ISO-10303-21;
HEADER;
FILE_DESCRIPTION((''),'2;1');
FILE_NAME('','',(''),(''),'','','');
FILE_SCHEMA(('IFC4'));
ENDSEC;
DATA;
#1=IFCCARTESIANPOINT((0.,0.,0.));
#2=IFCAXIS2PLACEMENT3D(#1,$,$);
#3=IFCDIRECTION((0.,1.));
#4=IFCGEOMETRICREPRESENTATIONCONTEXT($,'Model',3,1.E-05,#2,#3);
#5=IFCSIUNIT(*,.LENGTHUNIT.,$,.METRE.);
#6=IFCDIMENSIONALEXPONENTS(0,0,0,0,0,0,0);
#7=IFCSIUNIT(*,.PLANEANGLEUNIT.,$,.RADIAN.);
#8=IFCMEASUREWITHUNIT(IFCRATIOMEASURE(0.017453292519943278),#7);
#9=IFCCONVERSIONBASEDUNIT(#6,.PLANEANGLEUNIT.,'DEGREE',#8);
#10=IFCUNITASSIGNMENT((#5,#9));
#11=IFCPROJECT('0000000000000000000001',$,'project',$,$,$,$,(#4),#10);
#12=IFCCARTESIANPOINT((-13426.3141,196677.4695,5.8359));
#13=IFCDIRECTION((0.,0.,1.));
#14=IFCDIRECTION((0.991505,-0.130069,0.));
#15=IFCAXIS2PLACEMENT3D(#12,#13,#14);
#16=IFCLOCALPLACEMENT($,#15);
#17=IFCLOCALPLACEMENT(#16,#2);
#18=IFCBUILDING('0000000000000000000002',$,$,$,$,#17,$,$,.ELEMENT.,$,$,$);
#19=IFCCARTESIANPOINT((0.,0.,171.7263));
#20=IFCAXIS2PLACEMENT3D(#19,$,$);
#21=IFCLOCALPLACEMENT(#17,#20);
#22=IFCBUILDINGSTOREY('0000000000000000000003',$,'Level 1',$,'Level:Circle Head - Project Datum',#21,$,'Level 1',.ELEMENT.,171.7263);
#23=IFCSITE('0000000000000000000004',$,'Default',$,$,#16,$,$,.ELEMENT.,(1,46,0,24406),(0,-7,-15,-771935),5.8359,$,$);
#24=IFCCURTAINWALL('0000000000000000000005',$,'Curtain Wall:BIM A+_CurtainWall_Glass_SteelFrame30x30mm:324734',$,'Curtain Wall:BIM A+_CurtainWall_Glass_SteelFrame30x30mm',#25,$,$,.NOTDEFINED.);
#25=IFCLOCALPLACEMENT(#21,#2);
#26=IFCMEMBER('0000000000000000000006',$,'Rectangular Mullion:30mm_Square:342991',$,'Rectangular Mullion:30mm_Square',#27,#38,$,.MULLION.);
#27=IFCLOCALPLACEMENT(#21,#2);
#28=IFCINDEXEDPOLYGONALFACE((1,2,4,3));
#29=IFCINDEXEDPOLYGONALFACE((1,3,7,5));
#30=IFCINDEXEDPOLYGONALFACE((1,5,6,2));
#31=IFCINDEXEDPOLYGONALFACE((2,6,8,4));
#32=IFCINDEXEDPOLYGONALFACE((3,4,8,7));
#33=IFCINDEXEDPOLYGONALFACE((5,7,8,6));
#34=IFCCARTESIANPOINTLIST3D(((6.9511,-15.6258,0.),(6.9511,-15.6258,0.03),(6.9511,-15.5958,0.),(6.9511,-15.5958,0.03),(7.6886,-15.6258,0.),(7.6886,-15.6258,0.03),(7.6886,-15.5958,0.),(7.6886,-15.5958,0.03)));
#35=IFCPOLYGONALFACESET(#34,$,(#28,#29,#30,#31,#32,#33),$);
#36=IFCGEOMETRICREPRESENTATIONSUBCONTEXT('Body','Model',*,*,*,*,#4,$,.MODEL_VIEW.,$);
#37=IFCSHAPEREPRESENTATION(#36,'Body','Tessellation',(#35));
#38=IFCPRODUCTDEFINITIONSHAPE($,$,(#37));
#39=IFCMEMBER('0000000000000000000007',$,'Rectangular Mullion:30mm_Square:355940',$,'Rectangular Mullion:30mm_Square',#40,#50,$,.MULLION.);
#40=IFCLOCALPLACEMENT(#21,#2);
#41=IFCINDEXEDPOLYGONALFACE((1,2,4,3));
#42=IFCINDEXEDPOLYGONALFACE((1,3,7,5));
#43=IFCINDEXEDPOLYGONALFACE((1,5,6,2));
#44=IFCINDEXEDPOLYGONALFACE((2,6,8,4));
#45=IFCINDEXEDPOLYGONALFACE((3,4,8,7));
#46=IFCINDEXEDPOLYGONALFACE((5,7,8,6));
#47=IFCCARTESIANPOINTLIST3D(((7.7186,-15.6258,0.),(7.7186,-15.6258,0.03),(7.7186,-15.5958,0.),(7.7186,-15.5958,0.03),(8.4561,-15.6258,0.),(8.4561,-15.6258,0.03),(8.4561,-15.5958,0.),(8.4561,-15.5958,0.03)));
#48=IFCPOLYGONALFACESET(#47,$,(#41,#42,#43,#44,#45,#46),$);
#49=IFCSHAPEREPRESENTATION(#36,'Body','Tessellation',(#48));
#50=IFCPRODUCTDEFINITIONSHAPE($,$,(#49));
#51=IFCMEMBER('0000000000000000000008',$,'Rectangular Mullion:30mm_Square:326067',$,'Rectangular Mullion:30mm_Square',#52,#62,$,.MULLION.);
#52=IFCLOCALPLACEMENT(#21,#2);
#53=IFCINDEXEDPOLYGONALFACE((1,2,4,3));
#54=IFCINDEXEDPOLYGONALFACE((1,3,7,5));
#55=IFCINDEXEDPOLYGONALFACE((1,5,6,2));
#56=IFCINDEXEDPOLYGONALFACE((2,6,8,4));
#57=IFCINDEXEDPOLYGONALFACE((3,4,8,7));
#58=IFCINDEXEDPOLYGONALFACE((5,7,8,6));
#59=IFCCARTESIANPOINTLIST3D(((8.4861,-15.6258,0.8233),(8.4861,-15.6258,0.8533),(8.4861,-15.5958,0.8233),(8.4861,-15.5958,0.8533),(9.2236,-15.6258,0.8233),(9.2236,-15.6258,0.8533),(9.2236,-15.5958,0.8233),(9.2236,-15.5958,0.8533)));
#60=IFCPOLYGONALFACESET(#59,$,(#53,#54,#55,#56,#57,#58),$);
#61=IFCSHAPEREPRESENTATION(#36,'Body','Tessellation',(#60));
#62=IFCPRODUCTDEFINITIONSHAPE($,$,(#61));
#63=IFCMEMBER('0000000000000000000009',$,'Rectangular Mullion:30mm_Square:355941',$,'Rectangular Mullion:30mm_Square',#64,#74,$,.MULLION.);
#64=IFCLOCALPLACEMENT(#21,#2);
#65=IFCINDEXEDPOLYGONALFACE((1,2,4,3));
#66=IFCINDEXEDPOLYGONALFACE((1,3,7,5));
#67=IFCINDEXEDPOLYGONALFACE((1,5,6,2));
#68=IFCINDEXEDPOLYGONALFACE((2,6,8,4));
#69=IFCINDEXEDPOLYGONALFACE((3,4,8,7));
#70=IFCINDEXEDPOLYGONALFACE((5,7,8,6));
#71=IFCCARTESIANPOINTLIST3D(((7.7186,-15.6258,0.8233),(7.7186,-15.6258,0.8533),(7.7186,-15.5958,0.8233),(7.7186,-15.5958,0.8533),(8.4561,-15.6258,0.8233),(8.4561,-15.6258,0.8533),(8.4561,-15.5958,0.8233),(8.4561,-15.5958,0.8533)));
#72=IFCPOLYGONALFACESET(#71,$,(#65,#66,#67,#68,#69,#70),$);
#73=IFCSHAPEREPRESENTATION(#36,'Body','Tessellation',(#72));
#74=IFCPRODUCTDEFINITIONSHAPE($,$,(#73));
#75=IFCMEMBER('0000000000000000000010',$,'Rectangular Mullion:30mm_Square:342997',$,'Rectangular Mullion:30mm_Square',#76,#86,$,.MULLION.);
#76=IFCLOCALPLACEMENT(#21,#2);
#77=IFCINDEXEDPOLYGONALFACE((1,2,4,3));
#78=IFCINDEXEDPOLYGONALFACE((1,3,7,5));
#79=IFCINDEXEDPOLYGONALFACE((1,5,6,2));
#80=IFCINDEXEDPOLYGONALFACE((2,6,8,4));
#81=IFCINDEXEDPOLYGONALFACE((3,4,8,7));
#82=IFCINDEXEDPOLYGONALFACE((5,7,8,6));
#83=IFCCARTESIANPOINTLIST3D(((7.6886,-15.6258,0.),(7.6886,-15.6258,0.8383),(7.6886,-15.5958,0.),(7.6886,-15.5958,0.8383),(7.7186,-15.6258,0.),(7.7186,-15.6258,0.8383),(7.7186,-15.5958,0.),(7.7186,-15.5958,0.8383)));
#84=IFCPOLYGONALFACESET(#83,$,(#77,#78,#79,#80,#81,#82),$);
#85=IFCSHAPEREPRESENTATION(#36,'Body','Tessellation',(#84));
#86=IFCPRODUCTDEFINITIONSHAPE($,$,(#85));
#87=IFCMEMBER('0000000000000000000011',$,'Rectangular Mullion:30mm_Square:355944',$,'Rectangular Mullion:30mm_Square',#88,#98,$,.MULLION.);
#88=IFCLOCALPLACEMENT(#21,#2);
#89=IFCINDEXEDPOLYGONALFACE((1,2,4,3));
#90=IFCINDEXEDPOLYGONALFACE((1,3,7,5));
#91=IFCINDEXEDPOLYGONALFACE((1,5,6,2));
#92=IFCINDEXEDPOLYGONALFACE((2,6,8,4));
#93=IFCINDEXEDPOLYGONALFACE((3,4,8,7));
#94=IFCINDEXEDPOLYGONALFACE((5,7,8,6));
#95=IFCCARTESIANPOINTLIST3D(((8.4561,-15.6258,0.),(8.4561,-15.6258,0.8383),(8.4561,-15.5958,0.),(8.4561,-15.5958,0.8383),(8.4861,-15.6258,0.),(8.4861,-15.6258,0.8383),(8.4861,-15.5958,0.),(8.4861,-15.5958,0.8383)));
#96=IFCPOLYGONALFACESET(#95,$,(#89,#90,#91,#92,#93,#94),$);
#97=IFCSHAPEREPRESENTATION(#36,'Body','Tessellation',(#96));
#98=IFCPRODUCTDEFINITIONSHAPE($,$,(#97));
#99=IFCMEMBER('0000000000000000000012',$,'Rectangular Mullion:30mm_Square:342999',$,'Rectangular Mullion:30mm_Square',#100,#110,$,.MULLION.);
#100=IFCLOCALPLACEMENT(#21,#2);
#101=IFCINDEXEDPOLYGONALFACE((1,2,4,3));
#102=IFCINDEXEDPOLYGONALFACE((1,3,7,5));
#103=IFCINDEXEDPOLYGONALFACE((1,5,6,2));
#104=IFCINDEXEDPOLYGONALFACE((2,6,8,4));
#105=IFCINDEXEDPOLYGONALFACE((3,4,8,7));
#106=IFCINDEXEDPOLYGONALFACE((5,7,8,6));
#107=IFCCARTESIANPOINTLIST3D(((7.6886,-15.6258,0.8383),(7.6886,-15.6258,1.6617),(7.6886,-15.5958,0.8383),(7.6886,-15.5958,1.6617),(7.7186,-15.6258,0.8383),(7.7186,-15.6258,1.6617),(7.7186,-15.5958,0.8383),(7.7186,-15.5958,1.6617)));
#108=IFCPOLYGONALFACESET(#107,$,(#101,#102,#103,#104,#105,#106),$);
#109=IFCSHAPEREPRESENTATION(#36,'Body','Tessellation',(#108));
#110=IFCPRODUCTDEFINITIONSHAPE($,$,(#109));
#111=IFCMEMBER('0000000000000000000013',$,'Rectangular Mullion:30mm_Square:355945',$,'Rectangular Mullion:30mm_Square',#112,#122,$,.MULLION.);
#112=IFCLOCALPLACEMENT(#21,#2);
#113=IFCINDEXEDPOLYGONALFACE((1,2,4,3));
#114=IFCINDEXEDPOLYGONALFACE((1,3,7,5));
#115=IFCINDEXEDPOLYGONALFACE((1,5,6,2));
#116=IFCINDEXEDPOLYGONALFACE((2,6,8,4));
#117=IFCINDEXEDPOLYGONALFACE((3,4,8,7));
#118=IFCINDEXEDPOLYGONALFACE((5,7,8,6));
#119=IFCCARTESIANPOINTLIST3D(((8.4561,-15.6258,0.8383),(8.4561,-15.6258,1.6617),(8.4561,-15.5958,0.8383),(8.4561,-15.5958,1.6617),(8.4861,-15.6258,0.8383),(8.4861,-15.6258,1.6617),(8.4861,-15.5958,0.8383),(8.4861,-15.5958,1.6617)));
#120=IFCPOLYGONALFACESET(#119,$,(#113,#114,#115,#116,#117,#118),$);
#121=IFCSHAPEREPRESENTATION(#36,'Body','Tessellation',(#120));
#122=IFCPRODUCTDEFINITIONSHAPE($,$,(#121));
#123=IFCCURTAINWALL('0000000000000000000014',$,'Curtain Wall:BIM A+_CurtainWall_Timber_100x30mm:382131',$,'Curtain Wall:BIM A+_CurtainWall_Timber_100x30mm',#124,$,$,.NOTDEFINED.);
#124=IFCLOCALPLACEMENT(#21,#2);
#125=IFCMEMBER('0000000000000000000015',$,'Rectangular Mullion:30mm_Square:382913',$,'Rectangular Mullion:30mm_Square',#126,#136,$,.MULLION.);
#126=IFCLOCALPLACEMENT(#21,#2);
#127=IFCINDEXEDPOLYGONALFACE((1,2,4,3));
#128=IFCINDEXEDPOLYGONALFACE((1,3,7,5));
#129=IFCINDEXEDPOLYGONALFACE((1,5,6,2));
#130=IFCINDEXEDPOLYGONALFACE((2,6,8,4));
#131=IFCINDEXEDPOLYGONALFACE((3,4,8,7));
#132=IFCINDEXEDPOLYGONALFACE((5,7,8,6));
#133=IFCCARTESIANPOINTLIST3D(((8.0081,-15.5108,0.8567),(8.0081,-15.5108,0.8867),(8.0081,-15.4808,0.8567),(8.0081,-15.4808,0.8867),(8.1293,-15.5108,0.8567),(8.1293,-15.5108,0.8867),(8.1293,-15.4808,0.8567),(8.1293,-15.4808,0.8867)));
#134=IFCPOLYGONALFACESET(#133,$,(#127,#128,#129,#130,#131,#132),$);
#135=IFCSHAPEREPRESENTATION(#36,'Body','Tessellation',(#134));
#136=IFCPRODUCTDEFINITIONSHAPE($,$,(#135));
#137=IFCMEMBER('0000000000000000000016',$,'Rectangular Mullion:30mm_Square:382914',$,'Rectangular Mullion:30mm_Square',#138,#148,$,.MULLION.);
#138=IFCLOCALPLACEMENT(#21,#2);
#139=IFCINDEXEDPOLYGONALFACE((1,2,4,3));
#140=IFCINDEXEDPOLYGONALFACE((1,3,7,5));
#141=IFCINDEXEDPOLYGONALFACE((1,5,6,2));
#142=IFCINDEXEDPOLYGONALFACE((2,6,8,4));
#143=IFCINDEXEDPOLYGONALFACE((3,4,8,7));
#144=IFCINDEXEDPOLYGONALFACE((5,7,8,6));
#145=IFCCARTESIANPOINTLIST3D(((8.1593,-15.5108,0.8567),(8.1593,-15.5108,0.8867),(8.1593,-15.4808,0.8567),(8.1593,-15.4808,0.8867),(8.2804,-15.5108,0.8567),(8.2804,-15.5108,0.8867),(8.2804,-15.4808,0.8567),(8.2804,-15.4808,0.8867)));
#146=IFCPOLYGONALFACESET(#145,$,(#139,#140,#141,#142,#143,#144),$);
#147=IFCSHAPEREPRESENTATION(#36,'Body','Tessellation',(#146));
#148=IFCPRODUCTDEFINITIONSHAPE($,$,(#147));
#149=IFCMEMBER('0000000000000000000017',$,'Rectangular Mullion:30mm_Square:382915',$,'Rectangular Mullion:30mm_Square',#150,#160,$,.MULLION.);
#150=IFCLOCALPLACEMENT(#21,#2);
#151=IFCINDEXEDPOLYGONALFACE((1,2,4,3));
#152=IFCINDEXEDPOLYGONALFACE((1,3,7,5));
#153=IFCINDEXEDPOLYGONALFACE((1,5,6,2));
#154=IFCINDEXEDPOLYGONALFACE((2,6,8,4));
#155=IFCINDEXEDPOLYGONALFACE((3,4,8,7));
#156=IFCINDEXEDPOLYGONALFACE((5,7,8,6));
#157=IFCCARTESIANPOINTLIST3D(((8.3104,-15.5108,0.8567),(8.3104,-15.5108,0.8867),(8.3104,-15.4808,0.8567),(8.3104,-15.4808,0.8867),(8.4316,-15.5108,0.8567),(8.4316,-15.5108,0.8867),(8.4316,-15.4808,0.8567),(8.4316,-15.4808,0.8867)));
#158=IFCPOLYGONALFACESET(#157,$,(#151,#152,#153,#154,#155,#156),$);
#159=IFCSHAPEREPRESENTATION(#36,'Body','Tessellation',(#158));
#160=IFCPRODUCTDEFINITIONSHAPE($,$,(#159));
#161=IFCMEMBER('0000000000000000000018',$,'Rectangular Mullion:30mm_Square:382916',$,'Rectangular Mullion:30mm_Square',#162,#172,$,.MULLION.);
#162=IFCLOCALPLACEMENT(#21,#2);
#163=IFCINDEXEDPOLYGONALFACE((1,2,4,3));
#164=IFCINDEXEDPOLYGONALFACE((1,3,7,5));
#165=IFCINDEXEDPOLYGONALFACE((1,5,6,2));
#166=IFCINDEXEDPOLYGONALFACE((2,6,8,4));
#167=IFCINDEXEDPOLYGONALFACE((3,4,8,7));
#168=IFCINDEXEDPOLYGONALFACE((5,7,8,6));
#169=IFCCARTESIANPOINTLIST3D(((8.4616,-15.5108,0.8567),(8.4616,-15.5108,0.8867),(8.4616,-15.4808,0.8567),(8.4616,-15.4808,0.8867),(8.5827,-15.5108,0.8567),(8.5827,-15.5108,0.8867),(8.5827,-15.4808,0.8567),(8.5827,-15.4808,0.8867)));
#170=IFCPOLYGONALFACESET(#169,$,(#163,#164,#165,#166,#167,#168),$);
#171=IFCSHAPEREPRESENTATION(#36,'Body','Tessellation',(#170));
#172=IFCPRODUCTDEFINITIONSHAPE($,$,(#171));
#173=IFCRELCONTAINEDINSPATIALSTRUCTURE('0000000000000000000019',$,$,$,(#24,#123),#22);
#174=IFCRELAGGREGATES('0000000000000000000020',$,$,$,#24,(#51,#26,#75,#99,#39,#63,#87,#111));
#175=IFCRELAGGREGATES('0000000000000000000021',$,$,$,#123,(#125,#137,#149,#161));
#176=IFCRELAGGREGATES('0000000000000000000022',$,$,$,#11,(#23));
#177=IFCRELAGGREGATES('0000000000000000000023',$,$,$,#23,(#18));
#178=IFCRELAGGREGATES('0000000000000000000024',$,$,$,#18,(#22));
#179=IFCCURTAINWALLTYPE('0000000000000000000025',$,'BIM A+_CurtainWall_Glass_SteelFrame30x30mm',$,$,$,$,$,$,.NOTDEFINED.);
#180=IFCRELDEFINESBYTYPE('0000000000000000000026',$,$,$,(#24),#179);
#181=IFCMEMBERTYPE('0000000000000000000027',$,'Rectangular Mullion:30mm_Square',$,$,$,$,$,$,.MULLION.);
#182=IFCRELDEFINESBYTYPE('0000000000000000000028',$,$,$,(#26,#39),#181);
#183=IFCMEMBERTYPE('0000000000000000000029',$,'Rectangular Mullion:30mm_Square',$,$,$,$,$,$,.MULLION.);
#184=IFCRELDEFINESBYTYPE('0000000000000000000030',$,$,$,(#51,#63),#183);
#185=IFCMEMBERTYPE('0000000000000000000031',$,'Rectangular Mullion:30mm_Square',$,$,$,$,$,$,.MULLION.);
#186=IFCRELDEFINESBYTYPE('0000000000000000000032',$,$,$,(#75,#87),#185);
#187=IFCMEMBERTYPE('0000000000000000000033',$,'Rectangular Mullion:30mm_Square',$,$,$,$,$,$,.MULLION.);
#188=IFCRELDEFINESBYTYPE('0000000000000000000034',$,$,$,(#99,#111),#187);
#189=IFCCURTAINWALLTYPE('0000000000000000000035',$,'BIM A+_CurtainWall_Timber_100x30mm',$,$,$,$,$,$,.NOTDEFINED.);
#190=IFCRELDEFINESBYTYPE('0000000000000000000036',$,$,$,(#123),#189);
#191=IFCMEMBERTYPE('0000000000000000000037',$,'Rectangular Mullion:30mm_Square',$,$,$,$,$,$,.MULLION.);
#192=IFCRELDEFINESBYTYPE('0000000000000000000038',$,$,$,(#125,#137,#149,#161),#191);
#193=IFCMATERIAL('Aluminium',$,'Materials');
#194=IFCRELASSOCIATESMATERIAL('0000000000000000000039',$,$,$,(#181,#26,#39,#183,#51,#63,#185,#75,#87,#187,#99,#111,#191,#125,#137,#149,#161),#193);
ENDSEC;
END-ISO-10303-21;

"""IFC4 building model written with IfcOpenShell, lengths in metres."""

from ifc_helpers import new_model, entity, si_unit, converted_unit, direction, frame, origin, place, context, subcontext, project, spatial, indexed_curve, outline, extrude, source, transform, mapped, material, type_object, type_shapes, element, aggregate, save


model = new_model("IFC4")

# Units and contexts
model_context = context("Model", 3, precision=1e-05, world=origin(), true_north=direction((0.0, 1.0)))
body_context = subcontext(model_context, "Body", "Model", "MODEL_VIEW")
ifc_project = project(units=[si_unit("LENGTHUNIT", "METRE"), converted_unit("PLANEANGLEUNIT", "DEGREE", entity("IfcRatioMeasure", 0.017453292519943278), si_unit("PLANEANGLEUNIT", "RADIAN"), dimensions=[0, 0, 0, 0, 0, 0, 0])], contexts=[model_context])

# Site, building, storey
site_placement = place(None, frame((-13426.3141, 196677.4695, 5.8359), z_axis=(0.0, 0.0, 1.0), x_axis=(0.991505, -0.130069, 0.0)))
site = spatial("IfcSite", under=ifc_project, at=site_placement, Name="Default", CompositionType="ELEMENT", RefLatitude=(1, 46, 0, 24406), RefLongitude=(0, -7, -15, -771935), RefElevation=5.8359)
building_placement = place(site_placement, origin())
building = spatial("IfcBuilding", under=site, at=building_placement, CompositionType="ELEMENT")
storey_placement = place(building_placement, frame((0.0, 0.0, 171.7263)))
storey = spatial("IfcBuildingStorey", under=building, at=storey_placement, Name="Level 1", ObjectType="Level:Circle Head - Project Datum", LongName="Level 1", CompositionType="ELEMENT", Elevation=171.7263)

# Curtain walls, members
curtain_wall_type_1 = type_object("IfcCurtainWallType", Name="BIM A+_CurtainWall_Glass_SteelFrame30x30mm", PredefinedType="NOTDEFINED")
curtain_wall_1_placement = place(storey_placement, frame((0.0, 0.0, -171.7263)))
curtain_wall_1 = element("IfcCurtainWall", 1, at=curtain_wall_1_placement, inside=storey, type_object=curtain_wall_type_1, Name="Curtain Wall:BIM A+_CurtainWall_Glass_SteelFrame30x30mm:324734", ObjectType="Curtain Wall:BIM A+_CurtainWall_Glass_SteelFrame30x30mm", PredefinedType="NOTDEFINED")
ifc_material_1 = material(Name="Aluminium", Category="Materials")
member_type_1 = type_object("IfcMemberType", Name="Rectangular Mullion:30mm_Square", PredefinedType="MULLION", material=ifc_material_1)
shared_shape_1 = source(origin(), body_context, "Body", "SweptSolid", [
    extrude(outline(indexed_curve([(-0.015, -0.015), (0.015, -0.015), (0.015, 0.015), (-0.015, 0.015), (-0.015, -0.015)], self_intersect=False)), frame((-0.015, 0.0, -0.7375), z_axis=(0.0, 0.0, 1.0), x_axis=(0.0, -1.0, 0.0)), (0.0, 0.0, 1.0), 0.7375),
])
type_shapes(member_type_1, [shared_shape_1])
member_1_placement = place(curtain_wall_1_placement, frame((7.6886, -15.6108, 171.7263), z_axis=(1.0, 0.0, 0.0), x_axis=(0.0, 0.0, -1.0)))
member_1 = element("IfcMember", 2, at=member_1_placement, type_object=member_type_1, material=ifc_material_1, Name="Rectangular Mullion:30mm_Square:342991", ObjectType="Rectangular Mullion:30mm_Square", PredefinedType="MULLION", context=body_context, shape_type="MappedRepresentation", body=[
    mapped(shared_shape_1, transform((0.0, 0.0, 0.0), scale=1.0)),
])
member_2_placement = place(curtain_wall_1_placement, frame((8.4561, -15.6108, 171.7263), z_axis=(1.0, 0.0, 0.0), x_axis=(0.0, 0.0, -1.0)))
member_2 = element("IfcMember", 3, at=member_2_placement, type_object=member_type_1, material=ifc_material_1, Name="Rectangular Mullion:30mm_Square:355940", ObjectType="Rectangular Mullion:30mm_Square", PredefinedType="MULLION", context=body_context, shape_type="MappedRepresentation", body=[
    mapped(shared_shape_1, transform((0.0, 0.0, 0.0), scale=1.0)),
])
member_type_2 = type_object("IfcMemberType", Name="Rectangular Mullion:30mm_Square", PredefinedType="MULLION", material=ifc_material_1)
shared_shape_2 = source(origin(), body_context, "Body", "SweptSolid", [
    extrude(outline(indexed_curve([(-0.015, -0.015), (0.015, -0.015), (0.015, 0.015), (-0.015, 0.015), (-0.015, -0.015)], self_intersect=False)), frame((0.0, 0.0, -0.7375), z_axis=(0.0, 0.0, 1.0), x_axis=(0.0, -1.0, 0.0)), (0.0, 0.0, 1.0), 0.7375),
])
type_shapes(member_type_2, [shared_shape_2])
member_3_placement = place(curtain_wall_1_placement, frame((8.4861, -15.6108, 172.5646), z_axis=(-1.0, 0.0, 0.0), x_axis=(0.0, 0.0, 1.0)))
member_3 = element("IfcMember", 4, at=member_3_placement, type_object=member_type_2, material=ifc_material_1, Name="Rectangular Mullion:30mm_Square:326067", ObjectType="Rectangular Mullion:30mm_Square", PredefinedType="MULLION", context=body_context, shape_type="MappedRepresentation", body=[
    mapped(shared_shape_2, transform((0.0, 0.0, 0.0), scale=1.0)),
])
member_4_placement = place(curtain_wall_1_placement, frame((7.7186, -15.6108, 172.5646), z_axis=(-1.0, 0.0, 0.0), x_axis=(0.0, 0.0, 1.0)))
member_4 = element("IfcMember", 5, at=member_4_placement, type_object=member_type_2, material=ifc_material_1, Name="Rectangular Mullion:30mm_Square:355941", ObjectType="Rectangular Mullion:30mm_Square", PredefinedType="MULLION", context=body_context, shape_type="MappedRepresentation", body=[
    mapped(shared_shape_2, transform((0.0, 0.0, 0.0), scale=1.0)),
])
member_type_3 = type_object("IfcMemberType", Name="Rectangular Mullion:30mm_Square", PredefinedType="MULLION", material=ifc_material_1)
shared_shape_3 = source(origin(), body_context, "Body", "SweptSolid", [
    extrude(outline(indexed_curve([(-0.015, -0.015), (0.015, -0.015), (0.015, 0.015), (-0.015, 0.015), (-0.015, -0.015)], self_intersect=False)), frame((0.0, 0.0, -0.8383), z_axis=(0.0, 0.0, 1.0), x_axis=(0.0, -1.0, 0.0)), (0.0, 0.0, 1.0), 0.8383),
])
type_shapes(member_type_3, [shared_shape_3])
member_5_placement = place(curtain_wall_1_placement, frame((7.7036, -15.6108, 171.7263), z_axis=(0.0, 0.0, -1.0), x_axis=(-1.0, 0.0, 0.0)))
member_5 = element("IfcMember", 6, at=member_5_placement, type_object=member_type_3, material=ifc_material_1, Name="Rectangular Mullion:30mm_Square:342997", ObjectType="Rectangular Mullion:30mm_Square", PredefinedType="MULLION", context=body_context, shape_type="MappedRepresentation", body=[
    mapped(shared_shape_3, transform((0.0, 0.0, 0.0), scale=1.0)),
])
member_6_placement = place(curtain_wall_1_placement, frame((8.4711, -15.6108, 171.7263), z_axis=(0.0, 0.0, -1.0), x_axis=(-1.0, 0.0, 0.0)))
member_6 = element("IfcMember", 7, at=member_6_placement, type_object=member_type_3, material=ifc_material_1, Name="Rectangular Mullion:30mm_Square:355944", ObjectType="Rectangular Mullion:30mm_Square", PredefinedType="MULLION", context=body_context, shape_type="MappedRepresentation", body=[
    mapped(shared_shape_3, transform((0.0, 0.0, 0.0), scale=1.0)),
])
member_type_4 = type_object("IfcMemberType", Name="Rectangular Mullion:30mm_Square", PredefinedType="MULLION", material=ifc_material_1)
shared_shape_4 = source(origin(), body_context, "Body", "SweptSolid", [
    extrude(outline(indexed_curve([(-0.015, -0.015), (0.015, -0.015), (0.015, 0.015), (-0.015, 0.015), (-0.015, -0.015)], self_intersect=False)), frame((0.0, 0.0, -0.8233), z_axis=(0.0, 0.0, 1.0), x_axis=(0.0, -1.0, 0.0)), (0.0, 0.0, 1.0), 0.8233),
])
type_shapes(member_type_4, [shared_shape_4])
member_7_placement = place(curtain_wall_1_placement, frame((7.7036, -15.6108, 172.5646), z_axis=(0.0, 0.0, -1.0), x_axis=(-1.0, 0.0, 0.0)))
member_7 = element("IfcMember", 8, at=member_7_placement, type_object=member_type_4, material=ifc_material_1, Name="Rectangular Mullion:30mm_Square:342999", ObjectType="Rectangular Mullion:30mm_Square", PredefinedType="MULLION", context=body_context, shape_type="MappedRepresentation", body=[
    mapped(shared_shape_4, transform((0.0, 0.0, 0.0), scale=1.0)),
])
member_8_placement = place(curtain_wall_1_placement, frame((8.4711, -15.6108, 172.5646), z_axis=(0.0, 0.0, -1.0), x_axis=(-1.0, 0.0, 0.0)))
member_8 = element("IfcMember", 9, at=member_8_placement, type_object=member_type_4, material=ifc_material_1, Name="Rectangular Mullion:30mm_Square:355945", ObjectType="Rectangular Mullion:30mm_Square", PredefinedType="MULLION", context=body_context, shape_type="MappedRepresentation", body=[
    mapped(shared_shape_4, transform((0.0, 0.0, 0.0), scale=1.0)),
])
curtain_wall_type_2 = type_object("IfcCurtainWallType", Name="BIM A+_CurtainWall_Timber_100x30mm", PredefinedType="NOTDEFINED")
curtain_wall_2_placement = place(storey_placement, frame((0.0, 0.0, -171.7263)))
curtain_wall_2 = element("IfcCurtainWall", 10, at=curtain_wall_2_placement, inside=storey, type_object=curtain_wall_type_2, Name="Curtain Wall:BIM A+_CurtainWall_Timber_100x30mm:382131", ObjectType="Curtain Wall:BIM A+_CurtainWall_Timber_100x30mm", PredefinedType="NOTDEFINED")
member_type_5 = type_object("IfcMemberType", Name="Rectangular Mullion:30mm_Square", PredefinedType="MULLION", material=ifc_material_1)
shared_shape_5 = source(origin(), body_context, "Body", "SweptSolid", [
    extrude(outline(indexed_curve([(-0.015, -0.015), (0.015, -0.015), (0.015, 0.015), (-0.015, 0.015), (-0.015, -0.015)], self_intersect=False)), frame((0.0, 0.0, -0.1212), z_axis=(0.0, 0.0, 1.0), x_axis=(0.0, -1.0, 0.0)), (0.0, 0.0, 1.0), 0.1212),
])
type_shapes(member_type_5, [shared_shape_5])
member_9_placement = place(curtain_wall_2_placement, frame((8.1293, -15.4958, 172.598), z_axis=(1.0, 0.0, 0.0), x_axis=(0.0, 0.0, 1.0)))
member_9 = element("IfcMember", 11, at=member_9_placement, type_object=member_type_5, material=ifc_material_1, Name="Rectangular Mullion:30mm_Square:382913", ObjectType="Rectangular Mullion:30mm_Square", PredefinedType="MULLION", context=body_context, shape_type="MappedRepresentation", body=[
    mapped(shared_shape_5, transform((0.0, 0.0, 0.0), scale=1.0)),
])
member_10_placement = place(curtain_wall_2_placement, frame((8.2804, -15.4958, 172.598), z_axis=(1.0, 0.0, 0.0), x_axis=(0.0, 0.0, 1.0)))
member_10 = element("IfcMember", 12, at=member_10_placement, type_object=member_type_5, material=ifc_material_1, Name="Rectangular Mullion:30mm_Square:382914", ObjectType="Rectangular Mullion:30mm_Square", PredefinedType="MULLION", context=body_context, shape_type="MappedRepresentation", body=[
    mapped(shared_shape_5, transform((0.0, 0.0, 0.0), scale=1.0)),
])
member_11_placement = place(curtain_wall_2_placement, frame((8.4316, -15.4958, 172.598), z_axis=(1.0, 0.0, 0.0), x_axis=(0.0, 0.0, 1.0)))
member_11 = element("IfcMember", 13, at=member_11_placement, type_object=member_type_5, material=ifc_material_1, Name="Rectangular Mullion:30mm_Square:382915", ObjectType="Rectangular Mullion:30mm_Square", PredefinedType="MULLION", context=body_context, shape_type="MappedRepresentation", body=[
    mapped(shared_shape_5, transform((0.0, 0.0, 0.0), scale=1.0)),
])
member_12_placement = place(curtain_wall_2_placement, frame((8.5827, -15.4958, 172.598), z_axis=(1.0, 0.0, 0.0), x_axis=(0.0, 0.0, 1.0)))
member_12 = element("IfcMember", 14, at=member_12_placement, type_object=member_type_5, material=ifc_material_1, Name="Rectangular Mullion:30mm_Square:382916", ObjectType="Rectangular Mullion:30mm_Square", PredefinedType="MULLION", context=body_context, shape_type="MappedRepresentation", body=[
    mapped(shared_shape_5, transform((0.0, 0.0, 0.0), scale=1.0)),
])

aggregate(curtain_wall_1, [member_3, member_1, member_5, member_7, member_2, member_4, member_6, member_8])
aggregate(curtain_wall_2, [member_9, member_10, member_11, member_12])

save(model, "model.ifc")
